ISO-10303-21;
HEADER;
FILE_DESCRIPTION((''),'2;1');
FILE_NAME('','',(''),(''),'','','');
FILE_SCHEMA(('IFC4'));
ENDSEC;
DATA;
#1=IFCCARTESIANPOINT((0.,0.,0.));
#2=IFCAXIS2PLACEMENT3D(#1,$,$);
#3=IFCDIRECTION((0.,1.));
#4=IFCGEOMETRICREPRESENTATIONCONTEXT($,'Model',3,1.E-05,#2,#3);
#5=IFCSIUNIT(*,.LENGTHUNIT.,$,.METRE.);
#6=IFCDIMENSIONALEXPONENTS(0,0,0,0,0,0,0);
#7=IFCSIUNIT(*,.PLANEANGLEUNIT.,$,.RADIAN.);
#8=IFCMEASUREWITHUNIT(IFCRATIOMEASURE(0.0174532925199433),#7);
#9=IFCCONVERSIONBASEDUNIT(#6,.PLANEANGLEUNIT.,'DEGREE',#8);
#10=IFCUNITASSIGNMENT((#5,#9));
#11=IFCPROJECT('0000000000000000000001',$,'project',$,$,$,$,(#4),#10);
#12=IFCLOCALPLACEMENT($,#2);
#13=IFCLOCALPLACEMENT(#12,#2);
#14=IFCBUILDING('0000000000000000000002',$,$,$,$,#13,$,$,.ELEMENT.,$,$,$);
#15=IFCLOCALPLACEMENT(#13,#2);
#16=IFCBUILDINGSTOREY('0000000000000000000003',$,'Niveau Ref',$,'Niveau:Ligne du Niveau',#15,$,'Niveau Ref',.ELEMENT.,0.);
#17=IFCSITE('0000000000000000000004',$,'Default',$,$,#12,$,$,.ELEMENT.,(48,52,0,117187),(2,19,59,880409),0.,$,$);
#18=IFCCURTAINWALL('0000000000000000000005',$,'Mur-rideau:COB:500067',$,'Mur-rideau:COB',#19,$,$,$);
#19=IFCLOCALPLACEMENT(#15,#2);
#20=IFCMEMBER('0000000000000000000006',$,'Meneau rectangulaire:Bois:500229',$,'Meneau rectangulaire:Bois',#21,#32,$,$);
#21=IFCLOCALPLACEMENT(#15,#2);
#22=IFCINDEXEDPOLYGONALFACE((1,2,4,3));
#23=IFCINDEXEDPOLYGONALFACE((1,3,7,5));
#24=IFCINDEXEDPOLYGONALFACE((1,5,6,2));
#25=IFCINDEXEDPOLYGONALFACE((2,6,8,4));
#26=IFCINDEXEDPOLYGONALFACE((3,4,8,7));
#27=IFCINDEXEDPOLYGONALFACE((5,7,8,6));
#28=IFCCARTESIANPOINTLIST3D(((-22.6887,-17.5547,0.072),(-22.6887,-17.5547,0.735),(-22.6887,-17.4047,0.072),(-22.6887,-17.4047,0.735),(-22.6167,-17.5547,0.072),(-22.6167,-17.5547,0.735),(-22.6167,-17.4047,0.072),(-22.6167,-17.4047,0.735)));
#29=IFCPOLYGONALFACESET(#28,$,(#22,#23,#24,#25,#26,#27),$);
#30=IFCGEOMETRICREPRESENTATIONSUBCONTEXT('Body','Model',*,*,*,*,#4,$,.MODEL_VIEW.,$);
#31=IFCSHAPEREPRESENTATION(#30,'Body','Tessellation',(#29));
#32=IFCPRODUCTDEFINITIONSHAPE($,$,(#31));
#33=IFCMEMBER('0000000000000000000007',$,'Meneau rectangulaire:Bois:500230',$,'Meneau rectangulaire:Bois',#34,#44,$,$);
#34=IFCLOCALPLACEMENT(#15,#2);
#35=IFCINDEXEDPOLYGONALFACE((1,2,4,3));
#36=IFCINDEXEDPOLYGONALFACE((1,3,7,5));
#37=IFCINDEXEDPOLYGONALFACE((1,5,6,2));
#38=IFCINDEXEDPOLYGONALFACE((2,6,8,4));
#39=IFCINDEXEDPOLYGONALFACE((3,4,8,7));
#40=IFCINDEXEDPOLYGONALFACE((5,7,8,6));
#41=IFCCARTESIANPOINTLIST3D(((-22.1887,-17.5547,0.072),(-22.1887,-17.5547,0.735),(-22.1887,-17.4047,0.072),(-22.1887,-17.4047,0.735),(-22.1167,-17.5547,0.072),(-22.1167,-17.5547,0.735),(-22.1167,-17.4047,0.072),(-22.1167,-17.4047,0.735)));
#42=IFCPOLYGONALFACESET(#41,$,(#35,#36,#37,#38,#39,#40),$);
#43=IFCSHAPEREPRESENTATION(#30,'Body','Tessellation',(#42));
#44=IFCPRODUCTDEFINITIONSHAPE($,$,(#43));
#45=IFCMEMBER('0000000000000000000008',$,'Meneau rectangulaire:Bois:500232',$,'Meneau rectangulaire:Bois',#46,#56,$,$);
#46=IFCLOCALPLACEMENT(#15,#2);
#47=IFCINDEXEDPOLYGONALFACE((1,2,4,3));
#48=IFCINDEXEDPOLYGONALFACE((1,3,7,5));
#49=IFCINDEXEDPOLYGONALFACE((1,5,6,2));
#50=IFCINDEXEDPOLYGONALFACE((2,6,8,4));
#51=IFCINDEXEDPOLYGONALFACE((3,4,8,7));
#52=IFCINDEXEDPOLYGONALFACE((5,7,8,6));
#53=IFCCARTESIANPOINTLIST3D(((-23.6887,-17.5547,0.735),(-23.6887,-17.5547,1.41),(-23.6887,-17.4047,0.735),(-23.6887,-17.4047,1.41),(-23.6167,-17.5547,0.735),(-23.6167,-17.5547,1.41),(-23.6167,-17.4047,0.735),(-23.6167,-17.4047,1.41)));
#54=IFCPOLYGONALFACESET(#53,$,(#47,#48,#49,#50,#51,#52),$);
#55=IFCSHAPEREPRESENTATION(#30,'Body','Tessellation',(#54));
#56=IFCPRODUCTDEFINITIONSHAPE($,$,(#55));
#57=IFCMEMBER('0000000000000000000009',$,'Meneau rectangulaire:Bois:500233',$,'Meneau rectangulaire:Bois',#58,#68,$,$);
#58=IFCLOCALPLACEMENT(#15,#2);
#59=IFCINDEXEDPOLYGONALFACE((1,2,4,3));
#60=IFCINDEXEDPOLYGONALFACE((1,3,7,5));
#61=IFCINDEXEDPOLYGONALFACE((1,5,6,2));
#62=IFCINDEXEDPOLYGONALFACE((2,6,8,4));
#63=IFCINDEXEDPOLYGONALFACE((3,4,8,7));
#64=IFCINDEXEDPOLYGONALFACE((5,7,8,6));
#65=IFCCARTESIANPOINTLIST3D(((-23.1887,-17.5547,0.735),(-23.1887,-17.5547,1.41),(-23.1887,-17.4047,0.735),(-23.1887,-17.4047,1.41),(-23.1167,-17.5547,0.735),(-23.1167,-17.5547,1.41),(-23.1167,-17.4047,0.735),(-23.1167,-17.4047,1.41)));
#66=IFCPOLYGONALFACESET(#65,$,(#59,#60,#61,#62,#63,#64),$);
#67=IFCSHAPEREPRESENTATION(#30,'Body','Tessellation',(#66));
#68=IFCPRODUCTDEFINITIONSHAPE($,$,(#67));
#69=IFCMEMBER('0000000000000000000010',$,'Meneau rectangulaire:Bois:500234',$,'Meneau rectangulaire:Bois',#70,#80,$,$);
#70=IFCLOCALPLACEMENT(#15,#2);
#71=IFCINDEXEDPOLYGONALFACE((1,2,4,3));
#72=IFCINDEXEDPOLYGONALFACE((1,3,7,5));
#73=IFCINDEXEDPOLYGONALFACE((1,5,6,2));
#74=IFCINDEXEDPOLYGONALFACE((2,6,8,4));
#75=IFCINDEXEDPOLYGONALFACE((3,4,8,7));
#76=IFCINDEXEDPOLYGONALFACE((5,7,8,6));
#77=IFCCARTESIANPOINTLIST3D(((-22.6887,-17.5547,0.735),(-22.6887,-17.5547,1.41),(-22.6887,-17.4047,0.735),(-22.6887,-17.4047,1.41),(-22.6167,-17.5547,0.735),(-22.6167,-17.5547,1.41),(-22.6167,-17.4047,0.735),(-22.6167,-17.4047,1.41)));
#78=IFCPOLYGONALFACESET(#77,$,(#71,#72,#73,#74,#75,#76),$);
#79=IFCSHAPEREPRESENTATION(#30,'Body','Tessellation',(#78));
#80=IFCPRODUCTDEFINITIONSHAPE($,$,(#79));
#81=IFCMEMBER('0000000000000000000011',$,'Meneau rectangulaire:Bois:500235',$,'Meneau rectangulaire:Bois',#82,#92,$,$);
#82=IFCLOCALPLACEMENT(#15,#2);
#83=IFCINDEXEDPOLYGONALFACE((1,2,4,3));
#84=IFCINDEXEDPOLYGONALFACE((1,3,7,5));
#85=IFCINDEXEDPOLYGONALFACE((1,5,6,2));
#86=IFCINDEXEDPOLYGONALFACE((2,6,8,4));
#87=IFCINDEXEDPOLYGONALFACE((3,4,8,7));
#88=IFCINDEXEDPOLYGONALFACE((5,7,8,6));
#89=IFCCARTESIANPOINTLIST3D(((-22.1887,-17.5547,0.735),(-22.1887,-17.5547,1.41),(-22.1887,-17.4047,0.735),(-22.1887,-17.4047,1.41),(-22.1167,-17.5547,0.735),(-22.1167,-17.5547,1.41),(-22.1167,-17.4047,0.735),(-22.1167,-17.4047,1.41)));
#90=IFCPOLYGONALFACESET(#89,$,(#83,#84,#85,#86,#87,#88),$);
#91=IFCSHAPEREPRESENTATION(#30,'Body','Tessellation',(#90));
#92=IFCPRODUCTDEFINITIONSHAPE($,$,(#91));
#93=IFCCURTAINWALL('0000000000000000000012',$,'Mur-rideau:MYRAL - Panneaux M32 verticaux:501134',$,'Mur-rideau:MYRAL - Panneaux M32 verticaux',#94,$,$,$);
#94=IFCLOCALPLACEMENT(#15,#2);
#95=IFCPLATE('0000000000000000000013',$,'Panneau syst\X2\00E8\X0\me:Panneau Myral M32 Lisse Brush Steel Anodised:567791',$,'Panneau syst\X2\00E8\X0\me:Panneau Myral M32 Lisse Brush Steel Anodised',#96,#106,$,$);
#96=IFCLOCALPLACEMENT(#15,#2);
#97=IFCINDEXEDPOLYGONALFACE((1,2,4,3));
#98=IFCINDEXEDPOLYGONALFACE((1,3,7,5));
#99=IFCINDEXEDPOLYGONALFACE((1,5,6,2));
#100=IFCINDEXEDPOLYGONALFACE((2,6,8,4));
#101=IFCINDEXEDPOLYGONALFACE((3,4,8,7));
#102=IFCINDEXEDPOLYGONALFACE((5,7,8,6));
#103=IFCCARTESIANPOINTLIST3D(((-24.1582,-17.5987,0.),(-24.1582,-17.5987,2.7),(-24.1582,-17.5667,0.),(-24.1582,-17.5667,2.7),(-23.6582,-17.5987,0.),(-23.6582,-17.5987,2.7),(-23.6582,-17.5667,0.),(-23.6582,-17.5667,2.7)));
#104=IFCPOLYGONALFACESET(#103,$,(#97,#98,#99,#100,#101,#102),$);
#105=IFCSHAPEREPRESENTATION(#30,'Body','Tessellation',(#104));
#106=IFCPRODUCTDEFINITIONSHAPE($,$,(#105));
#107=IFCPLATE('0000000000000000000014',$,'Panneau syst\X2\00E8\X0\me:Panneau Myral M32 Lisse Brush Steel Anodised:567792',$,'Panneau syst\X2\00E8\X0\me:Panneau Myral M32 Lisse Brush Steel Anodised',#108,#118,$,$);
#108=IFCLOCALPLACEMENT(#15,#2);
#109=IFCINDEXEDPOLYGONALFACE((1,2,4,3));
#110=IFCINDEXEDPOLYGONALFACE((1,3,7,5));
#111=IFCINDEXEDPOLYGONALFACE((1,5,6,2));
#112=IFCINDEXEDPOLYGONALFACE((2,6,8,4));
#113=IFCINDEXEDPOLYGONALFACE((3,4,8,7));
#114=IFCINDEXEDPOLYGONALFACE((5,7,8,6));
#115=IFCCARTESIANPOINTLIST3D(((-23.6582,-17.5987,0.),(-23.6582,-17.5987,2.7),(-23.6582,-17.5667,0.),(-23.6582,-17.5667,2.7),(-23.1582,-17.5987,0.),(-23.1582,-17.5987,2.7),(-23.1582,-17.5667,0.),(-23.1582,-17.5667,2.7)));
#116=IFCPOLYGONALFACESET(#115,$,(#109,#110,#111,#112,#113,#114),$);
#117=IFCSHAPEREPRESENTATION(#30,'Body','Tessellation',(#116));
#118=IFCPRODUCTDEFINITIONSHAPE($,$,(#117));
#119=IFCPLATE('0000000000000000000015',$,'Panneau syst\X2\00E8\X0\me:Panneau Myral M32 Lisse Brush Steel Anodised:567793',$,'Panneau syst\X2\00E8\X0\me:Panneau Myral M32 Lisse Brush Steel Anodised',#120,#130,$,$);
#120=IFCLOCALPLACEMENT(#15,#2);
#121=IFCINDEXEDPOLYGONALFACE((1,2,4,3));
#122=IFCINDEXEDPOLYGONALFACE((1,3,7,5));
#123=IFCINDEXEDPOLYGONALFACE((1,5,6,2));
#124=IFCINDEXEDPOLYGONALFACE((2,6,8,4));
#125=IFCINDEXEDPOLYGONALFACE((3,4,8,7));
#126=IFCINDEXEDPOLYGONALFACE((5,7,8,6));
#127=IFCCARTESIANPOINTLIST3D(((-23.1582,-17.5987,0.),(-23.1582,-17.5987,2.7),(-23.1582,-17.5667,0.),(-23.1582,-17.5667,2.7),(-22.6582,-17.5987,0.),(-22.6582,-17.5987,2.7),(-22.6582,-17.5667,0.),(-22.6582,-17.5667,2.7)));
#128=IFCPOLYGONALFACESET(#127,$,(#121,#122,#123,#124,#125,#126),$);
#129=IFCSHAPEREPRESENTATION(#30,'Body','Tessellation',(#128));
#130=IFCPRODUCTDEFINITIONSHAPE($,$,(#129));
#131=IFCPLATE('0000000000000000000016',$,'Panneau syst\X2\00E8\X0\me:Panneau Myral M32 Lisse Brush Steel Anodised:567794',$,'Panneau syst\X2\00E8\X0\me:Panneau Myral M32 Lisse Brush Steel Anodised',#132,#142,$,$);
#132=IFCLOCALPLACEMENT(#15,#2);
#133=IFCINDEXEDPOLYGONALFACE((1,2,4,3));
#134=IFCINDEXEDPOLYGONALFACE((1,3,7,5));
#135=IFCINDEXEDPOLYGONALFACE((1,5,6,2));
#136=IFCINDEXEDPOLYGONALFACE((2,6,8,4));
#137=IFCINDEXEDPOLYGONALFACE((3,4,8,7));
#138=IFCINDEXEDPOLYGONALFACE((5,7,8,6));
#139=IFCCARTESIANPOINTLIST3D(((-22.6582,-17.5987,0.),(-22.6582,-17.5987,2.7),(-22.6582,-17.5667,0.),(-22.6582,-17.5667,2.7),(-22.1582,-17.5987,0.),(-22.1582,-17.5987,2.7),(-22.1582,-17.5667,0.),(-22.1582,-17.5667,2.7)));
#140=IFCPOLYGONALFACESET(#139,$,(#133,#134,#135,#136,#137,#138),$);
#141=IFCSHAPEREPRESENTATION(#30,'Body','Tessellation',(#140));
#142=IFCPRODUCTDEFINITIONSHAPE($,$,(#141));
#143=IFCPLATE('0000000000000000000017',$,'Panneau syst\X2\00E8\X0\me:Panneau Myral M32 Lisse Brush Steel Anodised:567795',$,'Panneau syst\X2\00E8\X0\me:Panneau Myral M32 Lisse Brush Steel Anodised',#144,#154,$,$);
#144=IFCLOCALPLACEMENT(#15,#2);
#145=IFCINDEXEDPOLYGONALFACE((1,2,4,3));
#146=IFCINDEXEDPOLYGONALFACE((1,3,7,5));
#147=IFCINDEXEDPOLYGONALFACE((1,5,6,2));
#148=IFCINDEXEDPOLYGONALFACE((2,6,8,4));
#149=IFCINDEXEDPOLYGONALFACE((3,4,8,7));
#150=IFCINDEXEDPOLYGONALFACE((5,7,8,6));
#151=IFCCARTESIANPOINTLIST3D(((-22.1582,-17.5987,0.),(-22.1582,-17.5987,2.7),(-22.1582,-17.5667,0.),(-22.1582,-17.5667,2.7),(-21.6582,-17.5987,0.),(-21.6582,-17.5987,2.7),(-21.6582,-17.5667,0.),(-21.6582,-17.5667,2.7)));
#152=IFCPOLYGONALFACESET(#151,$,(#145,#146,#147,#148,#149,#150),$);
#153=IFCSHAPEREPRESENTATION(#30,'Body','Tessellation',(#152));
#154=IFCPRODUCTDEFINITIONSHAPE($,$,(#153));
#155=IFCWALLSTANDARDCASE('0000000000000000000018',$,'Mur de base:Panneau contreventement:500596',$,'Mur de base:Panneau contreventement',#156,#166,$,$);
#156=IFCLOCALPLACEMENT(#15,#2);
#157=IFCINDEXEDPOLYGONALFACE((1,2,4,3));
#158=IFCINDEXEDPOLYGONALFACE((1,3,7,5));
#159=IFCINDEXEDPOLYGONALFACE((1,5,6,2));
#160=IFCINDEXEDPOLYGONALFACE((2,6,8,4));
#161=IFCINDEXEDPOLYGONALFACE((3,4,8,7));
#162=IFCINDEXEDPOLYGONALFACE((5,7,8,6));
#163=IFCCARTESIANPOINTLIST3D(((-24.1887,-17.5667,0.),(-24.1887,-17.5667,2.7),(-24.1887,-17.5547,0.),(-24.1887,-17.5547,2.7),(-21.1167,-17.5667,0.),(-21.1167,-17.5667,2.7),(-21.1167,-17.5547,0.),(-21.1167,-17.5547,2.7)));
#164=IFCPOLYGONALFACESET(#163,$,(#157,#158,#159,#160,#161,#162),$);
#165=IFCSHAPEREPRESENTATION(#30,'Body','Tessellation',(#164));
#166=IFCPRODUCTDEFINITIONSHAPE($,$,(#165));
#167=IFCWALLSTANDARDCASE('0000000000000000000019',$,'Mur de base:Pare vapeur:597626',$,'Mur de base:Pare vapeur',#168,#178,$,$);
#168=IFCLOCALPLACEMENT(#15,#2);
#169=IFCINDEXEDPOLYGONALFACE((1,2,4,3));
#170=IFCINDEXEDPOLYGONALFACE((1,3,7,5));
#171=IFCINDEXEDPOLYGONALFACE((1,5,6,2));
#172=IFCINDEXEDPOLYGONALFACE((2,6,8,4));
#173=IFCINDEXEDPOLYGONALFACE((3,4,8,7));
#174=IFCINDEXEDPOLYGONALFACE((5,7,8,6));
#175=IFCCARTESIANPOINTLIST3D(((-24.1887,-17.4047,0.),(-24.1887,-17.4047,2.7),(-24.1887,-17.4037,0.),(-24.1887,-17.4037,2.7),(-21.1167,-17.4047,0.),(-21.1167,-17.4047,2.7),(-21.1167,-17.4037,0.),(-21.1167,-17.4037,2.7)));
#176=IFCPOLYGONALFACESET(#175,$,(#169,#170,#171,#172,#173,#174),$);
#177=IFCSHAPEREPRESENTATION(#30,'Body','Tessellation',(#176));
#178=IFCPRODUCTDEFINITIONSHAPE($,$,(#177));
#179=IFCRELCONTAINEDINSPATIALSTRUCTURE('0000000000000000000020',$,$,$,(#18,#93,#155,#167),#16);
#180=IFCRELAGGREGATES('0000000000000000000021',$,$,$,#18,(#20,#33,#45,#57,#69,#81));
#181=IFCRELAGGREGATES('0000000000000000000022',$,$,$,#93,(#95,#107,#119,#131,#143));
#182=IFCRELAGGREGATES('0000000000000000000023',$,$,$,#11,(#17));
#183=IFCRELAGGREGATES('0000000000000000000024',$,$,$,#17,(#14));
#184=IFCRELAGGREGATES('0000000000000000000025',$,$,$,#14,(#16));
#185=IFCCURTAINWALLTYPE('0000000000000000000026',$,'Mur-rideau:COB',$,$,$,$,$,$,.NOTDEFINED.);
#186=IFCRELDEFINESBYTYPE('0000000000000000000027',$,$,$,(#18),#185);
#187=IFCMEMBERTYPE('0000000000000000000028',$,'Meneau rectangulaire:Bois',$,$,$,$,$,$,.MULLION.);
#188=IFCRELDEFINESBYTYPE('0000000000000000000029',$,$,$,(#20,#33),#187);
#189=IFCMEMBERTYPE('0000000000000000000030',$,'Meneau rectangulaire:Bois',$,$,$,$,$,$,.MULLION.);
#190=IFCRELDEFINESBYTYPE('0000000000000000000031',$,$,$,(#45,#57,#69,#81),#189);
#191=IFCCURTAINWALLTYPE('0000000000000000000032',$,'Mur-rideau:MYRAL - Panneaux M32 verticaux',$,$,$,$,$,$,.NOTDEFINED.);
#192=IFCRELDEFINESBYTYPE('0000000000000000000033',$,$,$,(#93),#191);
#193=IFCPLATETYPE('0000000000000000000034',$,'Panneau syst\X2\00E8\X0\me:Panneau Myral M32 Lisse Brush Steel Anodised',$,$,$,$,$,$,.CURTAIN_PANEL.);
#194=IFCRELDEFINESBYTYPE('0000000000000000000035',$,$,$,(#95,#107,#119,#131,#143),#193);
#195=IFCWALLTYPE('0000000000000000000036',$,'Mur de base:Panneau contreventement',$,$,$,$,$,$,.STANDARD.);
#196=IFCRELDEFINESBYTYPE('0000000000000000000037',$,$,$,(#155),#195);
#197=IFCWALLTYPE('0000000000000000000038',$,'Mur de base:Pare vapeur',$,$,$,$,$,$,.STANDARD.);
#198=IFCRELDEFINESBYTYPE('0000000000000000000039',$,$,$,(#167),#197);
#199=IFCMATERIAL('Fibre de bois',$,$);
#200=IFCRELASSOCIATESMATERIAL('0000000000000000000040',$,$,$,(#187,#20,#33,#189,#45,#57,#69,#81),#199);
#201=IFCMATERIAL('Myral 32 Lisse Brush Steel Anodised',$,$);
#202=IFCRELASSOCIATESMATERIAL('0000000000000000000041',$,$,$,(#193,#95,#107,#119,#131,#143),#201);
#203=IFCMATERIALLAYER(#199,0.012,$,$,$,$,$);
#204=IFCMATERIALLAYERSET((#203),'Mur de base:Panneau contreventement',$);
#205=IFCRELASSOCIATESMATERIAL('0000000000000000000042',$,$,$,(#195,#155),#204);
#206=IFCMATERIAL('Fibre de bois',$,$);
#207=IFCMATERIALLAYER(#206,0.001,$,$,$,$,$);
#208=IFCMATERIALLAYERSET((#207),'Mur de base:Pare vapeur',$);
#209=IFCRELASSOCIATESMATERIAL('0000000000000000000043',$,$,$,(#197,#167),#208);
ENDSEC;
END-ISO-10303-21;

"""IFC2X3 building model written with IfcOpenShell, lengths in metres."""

from ifc_helpers import new_model, entity, si_unit, converted_unit, direction, frame, frame_2d, origin, origin_2d_with_axis, place, context, subcontext, project, spatial, rectangle, extrude, source, transform, mapped, material, layer, layer_set, layer_usage, type_object, type_shapes, element, aggregate, save


model = new_model("IFC2X3")

# Units and contexts
model_context = context("Model", 3, precision=1e-05, world=origin(), true_north=direction((0.0, 1.0)))
body_context = subcontext(model_context, "Body", "Model", "MODEL_VIEW")
ifc_project = project(units=[si_unit("LENGTHUNIT", "METRE"), converted_unit("PLANEANGLEUNIT", "DEGREE", entity("IfcRatioMeasure", 0.0174532925199433), si_unit("PLANEANGLEUNIT", "RADIAN"), dimensions=[0, 0, 0, 0, 0, 0, 0])], contexts=[model_context])

# Site, building, storey
site_placement = place(None, origin())
site = spatial("IfcSite", under=ifc_project, at=site_placement, Name="Default", CompositionType="ELEMENT", RefLatitude=(48, 52, 0, 117187), RefLongitude=(2, 19, 59, 880409), RefElevation=0.0)
building_placement = place(site_placement, origin())
building = spatial("IfcBuilding", under=site, at=building_placement, CompositionType="ELEMENT")
storey_placement = place(building_placement, origin())
storey = spatial("IfcBuildingStorey", under=building, at=storey_placement, Name="Niveau Ref", ObjectType="Niveau:Ligne du Niveau", LongName="Niveau Ref", CompositionType="ELEMENT", Elevation=0.0)

# Curtain wall, members
curtain_wall_type_1 = type_object("IfcCurtainWallType", Name="Mur-rideau:COB", PredefinedType="NOTDEFINED")
curtain_wall_1_placement = place(storey_placement, origin())
curtain_wall_1 = element("IfcCurtainWall", 1, at=curtain_wall_1_placement, inside=storey, type_object=curtain_wall_type_1, Name="Mur-rideau:COB:500067", ObjectType="Mur-rideau:COB")
ifc_material_1 = material(Name="Fibre de bois")
member_type_1 = type_object("IfcMemberType", Name="Meneau rectangulaire:Bois", PredefinedType="MULLION", material=ifc_material_1)
shared_shape_1 = source(origin(), body_context, "Body", "SweptSolid", [
    extrude(rectangle(XDim=0.15, YDim=0.072, at=origin_2d_with_axis()), frame((-0.024, 0.0, -0.663), z_axis=(0.0, 0.0, 1.0), x_axis=(0.0, -1.0, 0.0)), (0.0, 0.0, 1.0), 0.663),
])
type_shapes(member_type_1, [shared_shape_1])
member_1_placement = place(storey_placement, frame((-22.6287, -17.4797, 0.072), z_axis=(0.0, 0.0, -1.0), x_axis=(1.0, 0.0, 0.0)))
member_1 = element("IfcMember", 2, at=member_1_placement, type_object=member_type_1, material=ifc_material_1, Name="Meneau rectangulaire:Bois:500229", ObjectType="Meneau rectangulaire:Bois", context=body_context, shape_type="MappedRepresentation", body=[
    mapped(shared_shape_1, transform((0.0, 0.0, 0.0), scale=1.0)),
])
member_2_placement = place(storey_placement, frame((-22.1287, -17.4797, 0.072), z_axis=(0.0, 0.0, -1.0), x_axis=(1.0, 0.0, 0.0)))
member_2 = element("IfcMember", 3, at=member_2_placement, type_object=member_type_1, material=ifc_material_1, Name="Meneau rectangulaire:Bois:500230", ObjectType="Meneau rectangulaire:Bois", context=body_context, shape_type="MappedRepresentation", body=[
    mapped(shared_shape_1, transform((0.0, 0.0, 0.0), scale=1.0)),
])
member_type_2 = type_object("IfcMemberType", Name="Meneau rectangulaire:Bois", PredefinedType="MULLION", material=ifc_material_1)
shared_shape_2 = source(origin(), body_context, "Body", "SweptSolid", [
    extrude(rectangle(XDim=0.15, YDim=0.072, at=origin_2d_with_axis()), frame((-0.024, 0.0, -0.675), z_axis=(0.0, 0.0, 1.0), x_axis=(0.0, -1.0, 0.0)), (0.0, 0.0, 1.0), 0.675),
])
type_shapes(member_type_2, [shared_shape_2])
member_3_placement = place(storey_placement, frame((-23.6287, -17.4797, 0.735), z_axis=(0.0, 0.0, -1.0), x_axis=(1.0, 0.0, 0.0)))
member_3 = element("IfcMember", 4, at=member_3_placement, type_object=member_type_2, material=ifc_material_1, Name="Meneau rectangulaire:Bois:500232", ObjectType="Meneau rectangulaire:Bois", context=body_context, shape_type="MappedRepresentation", body=[
    mapped(shared_shape_2, transform((0.0, 0.0, 0.0), scale=1.0)),
])
member_4_placement = place(storey_placement, frame((-23.1287, -17.4797, 0.735), z_axis=(0.0, 0.0, -1.0), x_axis=(1.0, 0.0, 0.0)))
member_4 = element("IfcMember", 5, at=member_4_placement, type_object=member_type_2, material=ifc_material_1, Name="Meneau rectangulaire:Bois:500233", ObjectType="Meneau rectangulaire:Bois", context=body_context, shape_type="MappedRepresentation", body=[
    mapped(shared_shape_2, transform((0.0, 0.0, 0.0), scale=1.0)),
])
member_5_placement = place(storey_placement, frame((-22.6287, -17.4797, 0.735), z_axis=(0.0, 0.0, -1.0), x_axis=(1.0, 0.0, 0.0)))
member_5 = element("IfcMember", 6, at=member_5_placement, type_object=member_type_2, material=ifc_material_1, Name="Meneau rectangulaire:Bois:500234", ObjectType="Meneau rectangulaire:Bois", context=body_context, shape_type="MappedRepresentation", body=[
    mapped(shared_shape_2, transform((0.0, 0.0, 0.0), scale=1.0)),
])
member_6_placement = place(storey_placement, frame((-22.1287, -17.4797, 0.735), z_axis=(0.0, 0.0, -1.0), x_axis=(1.0, 0.0, 0.0)))
member_6 = element("IfcMember", 7, at=member_6_placement, type_object=member_type_2, material=ifc_material_1, Name="Meneau rectangulaire:Bois:500235", ObjectType="Meneau rectangulaire:Bois", context=body_context, shape_type="MappedRepresentation", body=[
    mapped(shared_shape_2, transform((0.0, 0.0, 0.0), scale=1.0)),
])
aggregate(curtain_wall_1, [member_1, member_2, member_3, member_4, member_5, member_6])

# Curtain wall, plates
curtain_wall_type_2 = type_object("IfcCurtainWallType", Name="Mur-rideau:MYRAL - Panneaux M32 verticaux", PredefinedType="NOTDEFINED")
curtain_wall_2_placement = place(storey_placement, origin())
curtain_wall_2 = element("IfcCurtainWall", 8, at=curtain_wall_2_placement, inside=storey, type_object=curtain_wall_type_2, Name="Mur-rideau:MYRAL - Panneaux M32 verticaux:501134", ObjectType="Mur-rideau:MYRAL - Panneaux M32 verticaux")
ifc_material_2 = material(Name="Myral 32 Lisse Brush Steel Anodised")
plate_type = type_object("IfcPlateType", Name="Panneau système:Panneau Myral M32 Lisse Brush Steel Anodised", PredefinedType="CURTAIN_PANEL", material=ifc_material_2)
shared_shape_3 = source(origin(), body_context, "Body", "SweptSolid", [
    extrude(rectangle(XDim=0.032, YDim=0.5, at=origin_2d_with_axis()), frame((0.0, -0.016, 0.0), z_axis=(0.0, 0.0, 1.0), x_axis=(0.0, 1.0, 0.0)), (0.0, 0.0, 1.0), 2.7),
])
type_shapes(plate_type, [shared_shape_3])
plate_1_placement = place(curtain_wall_2_placement, frame((-23.9082, -17.5667, 0.0)))
plate_1 = element("IfcPlate", 9, at=plate_1_placement, type_object=plate_type, material=ifc_material_2, Name="Panneau système:Panneau Myral M32 Lisse Brush Steel Anodised:567791", ObjectType="Panneau système:Panneau Myral M32 Lisse Brush Steel Anodised", context=body_context, shape_type="MappedRepresentation", body=[
    mapped(shared_shape_3, transform((0.0, 0.0, 0.0), scale=1.0)),
])
plate_2_placement = place(curtain_wall_2_placement, frame((-23.4082, -17.5667, 0.0)))
plate_2 = element("IfcPlate", 10, at=plate_2_placement, type_object=plate_type, material=ifc_material_2, Name="Panneau système:Panneau Myral M32 Lisse Brush Steel Anodised:567792", ObjectType="Panneau système:Panneau Myral M32 Lisse Brush Steel Anodised", context=body_context, shape_type="MappedRepresentation", body=[
    mapped(shared_shape_3, transform((0.0, 0.0, 0.0), scale=1.0)),
])
plate_3_placement = place(curtain_wall_2_placement, frame((-22.9082, -17.5667, 0.0)))
plate_3 = element("IfcPlate", 11, at=plate_3_placement, type_object=plate_type, material=ifc_material_2, Name="Panneau système:Panneau Myral M32 Lisse Brush Steel Anodised:567793", ObjectType="Panneau système:Panneau Myral M32 Lisse Brush Steel Anodised", context=body_context, shape_type="MappedRepresentation", body=[
    mapped(shared_shape_3, transform((0.0, 0.0, 0.0), scale=1.0)),
])
plate_4_placement = place(curtain_wall_2_placement, frame((-22.4082, -17.5667, 0.0)))
plate_4 = element("IfcPlate", 12, at=plate_4_placement, type_object=plate_type, material=ifc_material_2, Name="Panneau système:Panneau Myral M32 Lisse Brush Steel Anodised:567794", ObjectType="Panneau système:Panneau Myral M32 Lisse Brush Steel Anodised", context=body_context, shape_type="MappedRepresentation", body=[
    mapped(shared_shape_3, transform((0.0, 0.0, 0.0), scale=1.0)),
])
plate_5_placement = place(curtain_wall_2_placement, frame((-21.9082, -17.5667, 0.0)))
plate_5 = element("IfcPlate", 13, at=plate_5_placement, type_object=plate_type, material=ifc_material_2, Name="Panneau système:Panneau Myral M32 Lisse Brush Steel Anodised:567795", ObjectType="Panneau système:Panneau Myral M32 Lisse Brush Steel Anodised", context=body_context, shape_type="MappedRepresentation", body=[
    mapped(shared_shape_3, transform((0.0, 0.0, 0.0), scale=1.0)),
])
aggregate(curtain_wall_2, [plate_1, plate_2, plate_3, plate_4, plate_5])

# Walls
ifc_layer_1 = layer(ifc_material_1, 0.012)
ifc_layer_set_1 = layer_set([ifc_layer_1], Name="Mur de base:Panneau contreventement")
ifc_layer_usage_1 = layer_usage(ifc_layer_set_1, "AXIS2", "NEGATIVE", 0.006)
wall_type_1 = type_object("IfcWallType", Name="Mur de base:Panneau contreventement", PredefinedType="STANDARD", material=ifc_layer_set_1)
wall_1_placement = place(storey_placement, frame((-24.1887, -17.5607, 0.0)))
element("IfcWallStandardCase", 14, at=wall_1_placement, inside=storey, type_object=wall_type_1, material=ifc_layer_usage_1, Name="Mur de base:Panneau contreventement:500596", ObjectType="Mur de base:Panneau contreventement", context=body_context, shape_type="SweptSolid", body=[
    extrude(rectangle(XDim=3.072, YDim=0.012, at=frame_2d((1.536, 0.0), x_axis=(-1.0, 0.0))), origin(), (0.0, 0.0, 1.0), 2.7),
])
ifc_material_3 = material(Name="Fibre de bois")
ifc_layer_2 = layer(ifc_material_3, 0.001)
ifc_layer_set_2 = layer_set([ifc_layer_2], Name="Mur de base:Pare vapeur")
ifc_layer_usage_2 = layer_usage(ifc_layer_set_2, "AXIS2", "NEGATIVE", 0.0005)
wall_type_2 = type_object("IfcWallType", Name="Mur de base:Pare vapeur", PredefinedType="STANDARD", material=ifc_layer_set_2)
wall_2_placement = place(storey_placement, frame((-24.1887, -17.4042, 0.0)))
element("IfcWallStandardCase", 15, at=wall_2_placement, inside=storey, type_object=wall_type_2, material=ifc_layer_usage_2, Name="Mur de base:Pare vapeur:597626", ObjectType="Mur de base:Pare vapeur", context=body_context, shape_type="SweptSolid", body=[
    extrude(rectangle(XDim=3.072, YDim=0.001, at=frame_2d((1.536, 0.0), x_axis=(-1.0, 0.0))), origin(), (0.0, 0.0, 1.0), 2.7),
])

save(model, "model.ifc")
